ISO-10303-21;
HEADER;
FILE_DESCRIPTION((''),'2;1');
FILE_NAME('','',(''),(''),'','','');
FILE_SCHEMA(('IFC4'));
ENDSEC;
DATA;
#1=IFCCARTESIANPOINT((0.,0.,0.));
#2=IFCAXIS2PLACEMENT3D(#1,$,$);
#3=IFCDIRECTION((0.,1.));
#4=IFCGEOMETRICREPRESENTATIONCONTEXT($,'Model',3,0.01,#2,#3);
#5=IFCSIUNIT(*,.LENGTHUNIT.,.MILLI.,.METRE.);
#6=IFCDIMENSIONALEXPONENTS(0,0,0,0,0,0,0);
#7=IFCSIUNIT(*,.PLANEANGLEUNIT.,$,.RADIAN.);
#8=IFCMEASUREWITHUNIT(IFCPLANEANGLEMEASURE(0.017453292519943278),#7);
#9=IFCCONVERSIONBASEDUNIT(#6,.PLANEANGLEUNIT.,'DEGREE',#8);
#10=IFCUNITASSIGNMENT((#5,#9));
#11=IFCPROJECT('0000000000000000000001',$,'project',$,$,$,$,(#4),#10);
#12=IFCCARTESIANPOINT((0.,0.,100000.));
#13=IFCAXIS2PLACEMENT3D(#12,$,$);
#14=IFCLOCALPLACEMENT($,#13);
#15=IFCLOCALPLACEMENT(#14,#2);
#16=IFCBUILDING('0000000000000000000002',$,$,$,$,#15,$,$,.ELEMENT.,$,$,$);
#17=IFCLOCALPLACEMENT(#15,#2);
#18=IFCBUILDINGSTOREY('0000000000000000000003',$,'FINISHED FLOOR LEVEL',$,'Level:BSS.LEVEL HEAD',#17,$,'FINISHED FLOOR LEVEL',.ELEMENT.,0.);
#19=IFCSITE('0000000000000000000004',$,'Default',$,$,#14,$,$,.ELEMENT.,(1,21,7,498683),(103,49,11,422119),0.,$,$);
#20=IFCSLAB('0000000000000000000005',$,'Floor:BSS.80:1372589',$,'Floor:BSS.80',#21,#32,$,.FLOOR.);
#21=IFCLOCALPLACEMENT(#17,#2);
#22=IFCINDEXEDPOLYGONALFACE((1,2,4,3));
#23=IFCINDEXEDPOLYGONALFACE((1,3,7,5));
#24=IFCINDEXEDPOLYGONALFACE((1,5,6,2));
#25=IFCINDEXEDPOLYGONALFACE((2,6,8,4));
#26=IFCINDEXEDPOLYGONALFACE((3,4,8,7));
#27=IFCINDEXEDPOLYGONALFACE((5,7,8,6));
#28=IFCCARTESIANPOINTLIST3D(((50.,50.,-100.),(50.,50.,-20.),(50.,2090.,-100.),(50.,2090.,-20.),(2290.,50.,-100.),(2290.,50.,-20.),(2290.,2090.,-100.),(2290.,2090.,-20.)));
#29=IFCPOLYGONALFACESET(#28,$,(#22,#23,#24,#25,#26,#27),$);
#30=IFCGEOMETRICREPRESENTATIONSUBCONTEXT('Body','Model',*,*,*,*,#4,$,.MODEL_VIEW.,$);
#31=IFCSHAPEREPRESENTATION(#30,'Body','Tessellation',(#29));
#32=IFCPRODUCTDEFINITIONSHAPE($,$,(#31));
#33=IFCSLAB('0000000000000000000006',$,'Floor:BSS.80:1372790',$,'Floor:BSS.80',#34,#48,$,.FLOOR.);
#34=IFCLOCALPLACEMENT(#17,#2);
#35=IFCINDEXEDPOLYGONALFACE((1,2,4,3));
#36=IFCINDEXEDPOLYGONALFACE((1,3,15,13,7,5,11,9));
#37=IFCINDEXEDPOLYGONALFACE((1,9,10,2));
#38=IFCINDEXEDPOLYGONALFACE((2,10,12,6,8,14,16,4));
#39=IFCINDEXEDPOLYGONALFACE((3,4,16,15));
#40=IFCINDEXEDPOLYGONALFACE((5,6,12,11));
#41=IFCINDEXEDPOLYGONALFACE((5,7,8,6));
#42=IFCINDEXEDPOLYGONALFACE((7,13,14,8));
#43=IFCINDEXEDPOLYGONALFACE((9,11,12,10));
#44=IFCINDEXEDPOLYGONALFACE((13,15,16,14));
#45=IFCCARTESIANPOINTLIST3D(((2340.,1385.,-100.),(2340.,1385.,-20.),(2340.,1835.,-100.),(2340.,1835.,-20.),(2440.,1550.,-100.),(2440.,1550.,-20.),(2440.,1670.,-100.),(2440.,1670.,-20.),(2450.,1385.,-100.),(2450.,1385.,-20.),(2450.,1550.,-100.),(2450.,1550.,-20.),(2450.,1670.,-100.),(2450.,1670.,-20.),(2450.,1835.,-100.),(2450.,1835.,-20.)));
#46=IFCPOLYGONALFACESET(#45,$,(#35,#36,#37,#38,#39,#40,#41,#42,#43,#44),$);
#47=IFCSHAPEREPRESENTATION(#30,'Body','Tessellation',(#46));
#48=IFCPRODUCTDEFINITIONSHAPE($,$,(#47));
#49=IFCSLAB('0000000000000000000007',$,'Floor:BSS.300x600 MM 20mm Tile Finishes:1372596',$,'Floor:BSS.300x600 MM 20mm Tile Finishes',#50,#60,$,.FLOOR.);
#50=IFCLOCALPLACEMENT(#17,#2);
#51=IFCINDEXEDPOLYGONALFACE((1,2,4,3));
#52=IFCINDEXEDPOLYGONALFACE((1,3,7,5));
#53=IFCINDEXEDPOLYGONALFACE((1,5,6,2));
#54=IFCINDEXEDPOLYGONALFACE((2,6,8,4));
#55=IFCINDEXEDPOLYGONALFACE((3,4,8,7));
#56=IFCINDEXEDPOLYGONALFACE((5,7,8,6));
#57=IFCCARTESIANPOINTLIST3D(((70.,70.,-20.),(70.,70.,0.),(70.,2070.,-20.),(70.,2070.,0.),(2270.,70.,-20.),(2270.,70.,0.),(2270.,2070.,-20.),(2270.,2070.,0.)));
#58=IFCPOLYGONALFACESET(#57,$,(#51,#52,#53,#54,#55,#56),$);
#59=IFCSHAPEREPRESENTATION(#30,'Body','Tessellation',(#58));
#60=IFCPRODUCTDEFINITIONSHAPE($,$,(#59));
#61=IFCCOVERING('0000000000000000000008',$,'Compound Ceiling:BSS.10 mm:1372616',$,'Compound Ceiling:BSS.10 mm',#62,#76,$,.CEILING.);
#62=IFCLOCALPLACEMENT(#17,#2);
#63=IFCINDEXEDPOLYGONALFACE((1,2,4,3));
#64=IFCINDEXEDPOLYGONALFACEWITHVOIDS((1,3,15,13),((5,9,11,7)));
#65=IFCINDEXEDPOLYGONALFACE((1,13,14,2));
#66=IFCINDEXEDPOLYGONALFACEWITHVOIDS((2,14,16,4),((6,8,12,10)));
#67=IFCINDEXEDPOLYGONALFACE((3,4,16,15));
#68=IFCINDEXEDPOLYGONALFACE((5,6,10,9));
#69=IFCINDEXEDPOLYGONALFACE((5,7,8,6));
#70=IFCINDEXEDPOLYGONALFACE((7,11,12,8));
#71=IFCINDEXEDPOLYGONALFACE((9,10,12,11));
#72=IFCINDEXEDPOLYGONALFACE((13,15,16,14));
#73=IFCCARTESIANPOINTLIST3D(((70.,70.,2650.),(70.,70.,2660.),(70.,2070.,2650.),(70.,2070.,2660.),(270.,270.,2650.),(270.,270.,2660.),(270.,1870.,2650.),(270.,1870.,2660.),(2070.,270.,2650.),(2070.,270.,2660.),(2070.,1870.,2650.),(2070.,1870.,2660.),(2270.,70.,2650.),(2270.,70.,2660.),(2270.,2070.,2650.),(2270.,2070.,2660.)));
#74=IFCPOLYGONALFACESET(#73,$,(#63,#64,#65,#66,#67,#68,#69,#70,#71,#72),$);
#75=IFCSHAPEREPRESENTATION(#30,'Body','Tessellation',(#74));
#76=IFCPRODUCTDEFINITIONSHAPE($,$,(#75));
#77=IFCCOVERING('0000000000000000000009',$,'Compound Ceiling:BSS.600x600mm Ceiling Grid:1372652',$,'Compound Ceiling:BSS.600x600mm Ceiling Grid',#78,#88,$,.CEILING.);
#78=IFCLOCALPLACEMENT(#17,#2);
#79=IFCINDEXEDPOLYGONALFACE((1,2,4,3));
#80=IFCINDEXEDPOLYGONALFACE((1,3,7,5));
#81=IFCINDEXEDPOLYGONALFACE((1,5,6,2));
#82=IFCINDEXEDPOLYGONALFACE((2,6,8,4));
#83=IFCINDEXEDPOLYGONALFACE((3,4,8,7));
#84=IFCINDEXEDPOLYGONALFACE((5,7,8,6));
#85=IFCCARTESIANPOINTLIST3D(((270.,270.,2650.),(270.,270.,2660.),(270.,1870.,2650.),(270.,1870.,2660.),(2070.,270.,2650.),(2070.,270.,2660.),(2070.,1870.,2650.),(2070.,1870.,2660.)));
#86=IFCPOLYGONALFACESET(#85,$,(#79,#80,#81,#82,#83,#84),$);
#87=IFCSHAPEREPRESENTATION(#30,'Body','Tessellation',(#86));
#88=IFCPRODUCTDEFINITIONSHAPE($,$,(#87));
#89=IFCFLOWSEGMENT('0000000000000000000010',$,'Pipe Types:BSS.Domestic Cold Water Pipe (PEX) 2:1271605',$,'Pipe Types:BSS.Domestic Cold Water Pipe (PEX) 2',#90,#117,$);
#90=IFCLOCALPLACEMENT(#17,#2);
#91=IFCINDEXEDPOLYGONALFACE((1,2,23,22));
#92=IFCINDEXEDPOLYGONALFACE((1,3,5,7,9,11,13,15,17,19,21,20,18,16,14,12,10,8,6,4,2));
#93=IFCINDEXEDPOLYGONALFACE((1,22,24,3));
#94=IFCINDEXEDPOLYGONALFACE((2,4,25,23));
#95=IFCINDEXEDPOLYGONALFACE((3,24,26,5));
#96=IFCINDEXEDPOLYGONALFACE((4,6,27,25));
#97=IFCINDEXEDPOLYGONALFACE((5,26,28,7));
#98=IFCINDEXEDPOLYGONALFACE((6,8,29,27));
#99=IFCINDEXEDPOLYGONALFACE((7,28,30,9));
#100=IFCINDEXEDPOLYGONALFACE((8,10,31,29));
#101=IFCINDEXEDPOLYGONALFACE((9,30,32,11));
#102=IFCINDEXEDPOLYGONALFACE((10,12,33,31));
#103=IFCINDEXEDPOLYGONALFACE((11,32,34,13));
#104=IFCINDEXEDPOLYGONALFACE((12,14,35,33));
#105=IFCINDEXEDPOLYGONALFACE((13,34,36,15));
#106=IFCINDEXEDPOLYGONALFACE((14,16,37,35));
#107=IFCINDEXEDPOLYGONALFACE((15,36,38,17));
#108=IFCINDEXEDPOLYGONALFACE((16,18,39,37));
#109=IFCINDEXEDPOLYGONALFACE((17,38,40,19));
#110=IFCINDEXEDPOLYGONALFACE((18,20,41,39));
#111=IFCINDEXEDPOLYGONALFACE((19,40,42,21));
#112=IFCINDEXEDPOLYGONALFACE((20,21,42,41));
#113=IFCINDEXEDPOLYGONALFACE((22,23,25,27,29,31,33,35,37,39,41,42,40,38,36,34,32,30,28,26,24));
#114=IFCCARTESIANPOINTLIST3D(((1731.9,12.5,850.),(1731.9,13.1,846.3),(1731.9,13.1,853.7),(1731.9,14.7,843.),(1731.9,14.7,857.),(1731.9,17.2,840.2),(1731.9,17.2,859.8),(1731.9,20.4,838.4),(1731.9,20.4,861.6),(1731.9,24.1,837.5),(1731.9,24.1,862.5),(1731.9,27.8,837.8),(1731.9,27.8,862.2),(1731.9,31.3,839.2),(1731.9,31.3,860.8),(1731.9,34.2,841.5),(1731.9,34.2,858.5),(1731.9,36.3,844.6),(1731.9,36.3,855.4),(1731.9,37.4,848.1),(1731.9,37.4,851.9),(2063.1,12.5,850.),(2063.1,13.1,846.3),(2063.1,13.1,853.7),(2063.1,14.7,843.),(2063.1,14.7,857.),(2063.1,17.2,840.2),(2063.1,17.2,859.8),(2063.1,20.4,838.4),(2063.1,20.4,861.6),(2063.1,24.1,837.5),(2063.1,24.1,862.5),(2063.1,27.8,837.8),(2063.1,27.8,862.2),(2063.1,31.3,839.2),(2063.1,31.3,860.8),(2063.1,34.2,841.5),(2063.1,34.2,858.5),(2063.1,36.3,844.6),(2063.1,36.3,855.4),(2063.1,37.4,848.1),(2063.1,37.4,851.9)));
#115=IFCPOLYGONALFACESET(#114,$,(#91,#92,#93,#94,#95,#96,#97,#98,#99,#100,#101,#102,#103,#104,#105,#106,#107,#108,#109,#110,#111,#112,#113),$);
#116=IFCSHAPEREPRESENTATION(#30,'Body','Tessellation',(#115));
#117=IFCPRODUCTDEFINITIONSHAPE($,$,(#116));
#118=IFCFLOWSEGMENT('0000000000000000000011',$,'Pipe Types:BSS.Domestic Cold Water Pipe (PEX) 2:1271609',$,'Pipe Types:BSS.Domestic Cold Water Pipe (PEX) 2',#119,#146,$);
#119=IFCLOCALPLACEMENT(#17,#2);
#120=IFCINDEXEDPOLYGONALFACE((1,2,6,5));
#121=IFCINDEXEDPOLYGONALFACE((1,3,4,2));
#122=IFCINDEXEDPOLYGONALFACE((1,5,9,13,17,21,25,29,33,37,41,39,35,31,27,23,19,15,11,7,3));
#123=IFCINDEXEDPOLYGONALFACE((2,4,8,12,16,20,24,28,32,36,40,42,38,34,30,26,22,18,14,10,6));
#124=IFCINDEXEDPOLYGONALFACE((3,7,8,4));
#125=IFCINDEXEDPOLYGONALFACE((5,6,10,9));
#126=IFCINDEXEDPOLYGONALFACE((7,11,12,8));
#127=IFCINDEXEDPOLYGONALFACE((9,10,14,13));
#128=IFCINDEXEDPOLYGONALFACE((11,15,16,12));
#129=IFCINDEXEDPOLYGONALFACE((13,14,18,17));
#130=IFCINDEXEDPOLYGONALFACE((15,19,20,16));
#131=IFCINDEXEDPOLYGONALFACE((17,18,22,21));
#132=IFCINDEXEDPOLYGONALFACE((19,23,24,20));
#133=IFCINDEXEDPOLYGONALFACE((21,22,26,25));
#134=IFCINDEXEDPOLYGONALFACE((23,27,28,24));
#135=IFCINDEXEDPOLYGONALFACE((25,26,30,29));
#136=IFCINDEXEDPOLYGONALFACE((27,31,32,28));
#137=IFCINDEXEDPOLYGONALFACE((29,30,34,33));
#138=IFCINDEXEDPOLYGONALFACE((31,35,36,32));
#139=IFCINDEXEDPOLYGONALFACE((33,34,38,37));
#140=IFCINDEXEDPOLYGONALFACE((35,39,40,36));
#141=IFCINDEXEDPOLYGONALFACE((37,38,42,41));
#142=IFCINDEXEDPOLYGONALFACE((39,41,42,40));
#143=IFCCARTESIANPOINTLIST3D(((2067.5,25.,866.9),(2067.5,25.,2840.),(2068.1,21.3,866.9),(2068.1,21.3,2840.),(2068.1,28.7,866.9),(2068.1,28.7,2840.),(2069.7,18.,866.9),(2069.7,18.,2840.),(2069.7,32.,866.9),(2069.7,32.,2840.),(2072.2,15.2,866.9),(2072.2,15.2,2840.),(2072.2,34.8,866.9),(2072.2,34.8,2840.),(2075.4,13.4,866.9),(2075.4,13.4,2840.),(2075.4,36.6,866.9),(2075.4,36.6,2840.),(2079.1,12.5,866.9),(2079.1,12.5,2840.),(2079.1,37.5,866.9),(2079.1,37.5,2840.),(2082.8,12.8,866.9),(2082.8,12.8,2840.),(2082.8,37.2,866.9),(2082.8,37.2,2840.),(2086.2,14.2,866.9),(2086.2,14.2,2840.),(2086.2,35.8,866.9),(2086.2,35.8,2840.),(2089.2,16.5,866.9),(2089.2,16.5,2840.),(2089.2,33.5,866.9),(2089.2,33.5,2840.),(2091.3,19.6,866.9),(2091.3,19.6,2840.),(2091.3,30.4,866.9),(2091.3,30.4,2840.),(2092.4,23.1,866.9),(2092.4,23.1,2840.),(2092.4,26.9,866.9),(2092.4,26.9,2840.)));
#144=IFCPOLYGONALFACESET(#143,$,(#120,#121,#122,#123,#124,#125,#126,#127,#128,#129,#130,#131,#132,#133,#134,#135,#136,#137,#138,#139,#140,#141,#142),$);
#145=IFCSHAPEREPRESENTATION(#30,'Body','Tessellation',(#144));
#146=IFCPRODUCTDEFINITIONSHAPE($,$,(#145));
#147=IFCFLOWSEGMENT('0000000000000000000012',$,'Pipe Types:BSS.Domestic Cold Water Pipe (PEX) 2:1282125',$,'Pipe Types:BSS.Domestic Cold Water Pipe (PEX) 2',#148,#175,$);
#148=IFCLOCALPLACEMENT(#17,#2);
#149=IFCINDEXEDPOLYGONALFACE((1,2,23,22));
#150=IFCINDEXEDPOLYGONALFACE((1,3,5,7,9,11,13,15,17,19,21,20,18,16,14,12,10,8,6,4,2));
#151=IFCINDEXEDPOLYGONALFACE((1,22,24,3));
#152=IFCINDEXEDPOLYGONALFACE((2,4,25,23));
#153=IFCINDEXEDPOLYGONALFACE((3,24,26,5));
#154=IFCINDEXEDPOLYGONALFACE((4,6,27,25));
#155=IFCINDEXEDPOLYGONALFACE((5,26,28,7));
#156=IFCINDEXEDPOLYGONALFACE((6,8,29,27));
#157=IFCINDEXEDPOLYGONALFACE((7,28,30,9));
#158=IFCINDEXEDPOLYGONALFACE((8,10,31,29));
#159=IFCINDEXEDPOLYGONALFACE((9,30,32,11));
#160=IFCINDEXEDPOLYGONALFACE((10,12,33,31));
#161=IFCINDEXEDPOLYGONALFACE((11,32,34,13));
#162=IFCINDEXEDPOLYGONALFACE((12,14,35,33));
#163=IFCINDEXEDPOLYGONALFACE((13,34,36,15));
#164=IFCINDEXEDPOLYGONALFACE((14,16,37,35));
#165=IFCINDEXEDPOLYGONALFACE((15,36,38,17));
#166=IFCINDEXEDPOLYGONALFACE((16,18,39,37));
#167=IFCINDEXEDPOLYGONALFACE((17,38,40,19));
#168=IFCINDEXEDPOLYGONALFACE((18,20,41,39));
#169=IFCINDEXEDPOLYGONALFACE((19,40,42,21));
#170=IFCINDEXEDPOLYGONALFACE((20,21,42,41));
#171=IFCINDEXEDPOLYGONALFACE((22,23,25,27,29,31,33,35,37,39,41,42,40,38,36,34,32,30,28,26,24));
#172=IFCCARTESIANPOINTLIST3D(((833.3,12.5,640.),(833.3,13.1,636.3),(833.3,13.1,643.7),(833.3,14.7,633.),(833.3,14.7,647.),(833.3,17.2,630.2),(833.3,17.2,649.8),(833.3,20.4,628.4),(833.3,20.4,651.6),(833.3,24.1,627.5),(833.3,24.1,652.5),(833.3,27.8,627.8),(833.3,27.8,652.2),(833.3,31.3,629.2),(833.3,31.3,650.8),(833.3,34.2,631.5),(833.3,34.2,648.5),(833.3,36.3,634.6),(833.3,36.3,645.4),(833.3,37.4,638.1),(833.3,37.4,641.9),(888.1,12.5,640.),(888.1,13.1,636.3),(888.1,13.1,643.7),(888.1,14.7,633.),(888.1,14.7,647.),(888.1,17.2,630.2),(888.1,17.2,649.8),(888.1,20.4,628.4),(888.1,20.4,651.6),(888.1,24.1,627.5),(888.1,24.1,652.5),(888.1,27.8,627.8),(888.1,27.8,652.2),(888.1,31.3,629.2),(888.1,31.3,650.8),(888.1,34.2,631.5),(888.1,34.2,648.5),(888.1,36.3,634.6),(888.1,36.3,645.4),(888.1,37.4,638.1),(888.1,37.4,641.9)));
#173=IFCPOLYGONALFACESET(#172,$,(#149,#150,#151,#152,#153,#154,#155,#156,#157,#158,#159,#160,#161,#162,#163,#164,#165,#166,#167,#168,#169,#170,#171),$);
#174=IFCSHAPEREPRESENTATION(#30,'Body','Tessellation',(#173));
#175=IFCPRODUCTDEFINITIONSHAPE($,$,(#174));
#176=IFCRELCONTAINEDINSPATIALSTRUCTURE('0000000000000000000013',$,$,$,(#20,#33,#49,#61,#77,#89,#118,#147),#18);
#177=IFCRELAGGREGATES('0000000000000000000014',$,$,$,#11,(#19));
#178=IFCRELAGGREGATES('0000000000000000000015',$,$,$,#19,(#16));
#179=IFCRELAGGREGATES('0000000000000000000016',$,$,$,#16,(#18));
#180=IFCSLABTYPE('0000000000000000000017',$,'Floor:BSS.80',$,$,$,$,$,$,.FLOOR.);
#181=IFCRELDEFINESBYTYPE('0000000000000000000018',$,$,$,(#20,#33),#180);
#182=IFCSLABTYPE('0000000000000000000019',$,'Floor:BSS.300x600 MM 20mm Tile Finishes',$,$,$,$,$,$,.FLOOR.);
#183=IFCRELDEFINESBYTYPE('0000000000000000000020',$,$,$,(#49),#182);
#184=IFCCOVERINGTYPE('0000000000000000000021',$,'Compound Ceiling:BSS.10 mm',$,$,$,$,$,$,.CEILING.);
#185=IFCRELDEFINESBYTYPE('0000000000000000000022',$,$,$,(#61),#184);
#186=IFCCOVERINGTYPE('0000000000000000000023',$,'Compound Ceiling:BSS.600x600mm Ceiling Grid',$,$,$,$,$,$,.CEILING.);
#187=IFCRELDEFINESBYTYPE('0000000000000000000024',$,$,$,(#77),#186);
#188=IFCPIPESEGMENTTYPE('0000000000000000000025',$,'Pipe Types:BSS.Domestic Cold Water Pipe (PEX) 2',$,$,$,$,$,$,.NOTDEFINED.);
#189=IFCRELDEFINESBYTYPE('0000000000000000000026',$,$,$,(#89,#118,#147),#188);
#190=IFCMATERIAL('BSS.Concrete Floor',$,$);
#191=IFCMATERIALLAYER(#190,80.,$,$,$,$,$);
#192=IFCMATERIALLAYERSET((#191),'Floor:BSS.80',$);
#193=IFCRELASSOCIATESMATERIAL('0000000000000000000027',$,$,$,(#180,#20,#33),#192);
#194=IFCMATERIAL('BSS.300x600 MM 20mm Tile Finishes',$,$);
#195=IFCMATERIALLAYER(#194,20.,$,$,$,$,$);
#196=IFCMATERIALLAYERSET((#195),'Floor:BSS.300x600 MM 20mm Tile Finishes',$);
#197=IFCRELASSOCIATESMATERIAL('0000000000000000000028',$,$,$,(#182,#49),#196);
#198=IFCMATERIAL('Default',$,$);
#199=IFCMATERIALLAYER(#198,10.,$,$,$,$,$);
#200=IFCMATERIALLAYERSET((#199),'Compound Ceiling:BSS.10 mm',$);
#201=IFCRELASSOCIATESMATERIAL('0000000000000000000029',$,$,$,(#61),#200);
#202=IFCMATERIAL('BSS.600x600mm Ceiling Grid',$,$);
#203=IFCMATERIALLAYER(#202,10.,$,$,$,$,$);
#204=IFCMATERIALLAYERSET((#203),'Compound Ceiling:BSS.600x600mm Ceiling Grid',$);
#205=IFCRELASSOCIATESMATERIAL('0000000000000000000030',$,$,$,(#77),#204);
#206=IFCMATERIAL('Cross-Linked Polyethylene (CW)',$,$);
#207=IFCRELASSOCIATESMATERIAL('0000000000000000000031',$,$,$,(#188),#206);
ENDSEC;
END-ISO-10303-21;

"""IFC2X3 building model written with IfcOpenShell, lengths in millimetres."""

from ifc_helpers import new_model, entity, si_unit, converted_unit, direction, frame, frame_2d, origin, origin_2d_with_axis, place, context, subcontext, project, spatial, polyline, rectangle, circle, outline, extrude, material, layer, layer_set, layer_usage, type_object, element, save


model = new_model("IFC2X3")

# Units and contexts
model_context = context("Model", 3, precision=0.01, world=origin(), true_north=direction((0.0, 1.0)))
body_context = subcontext(model_context, "Body", "Model", "MODEL_VIEW")
ifc_project = project(units=[si_unit("LENGTHUNIT", "METRE", prefix="MILLI"), converted_unit("PLANEANGLEUNIT", "DEGREE", entity("IfcPlaneAngleMeasure", 0.017453292519943278), si_unit("PLANEANGLEUNIT", "RADIAN"), dimensions=[0, 0, 0, 0, 0, 0, 0])], contexts=[model_context])

# Site, building, storey
site_placement = place(None, frame((0.0, 0.0, 100000.0)))
site = spatial("IfcSite", under=ifc_project, at=site_placement, Name="Default", CompositionType="ELEMENT", RefLatitude=(1, 21, 7, 498683), RefLongitude=(103, 49, 11, 422119), RefElevation=0.0)
building_placement = place(site_placement, origin())
building = spatial("IfcBuilding", under=site, at=building_placement, CompositionType="ELEMENT")
storey_placement = place(building_placement, origin())
storey = spatial("IfcBuildingStorey", under=building, at=storey_placement, Name="FINISHED FLOOR LEVEL", ObjectType="Level:BSS.LEVEL HEAD", LongName="FINISHED FLOOR LEVEL", CompositionType="ELEMENT", Elevation=0.0)

# Slabs
ifc_material_1 = material(Name="BSS.Concrete Floor")
ifc_layer_1 = layer(ifc_material_1, 80.0)
ifc_layer_set_1 = layer_set([ifc_layer_1], Name="Floor:BSS.80")
ifc_layer_usage_1 = layer_usage(ifc_layer_set_1, "AXIS3", "POSITIVE", 0.0)
slab_type_1 = type_object("IfcSlabType", Name="Floor:BSS.80", PredefinedType="FLOOR", material=ifc_layer_set_1)
slab_1_placement = place(storey_placement, origin())
element("IfcSlab", 1, at=slab_1_placement, inside=storey, type_object=slab_type_1, material=ifc_layer_usage_1, Name="Floor:BSS.80:1372589", ObjectType="Floor:BSS.80", PredefinedType="FLOOR", context=body_context, shape_type="SweptSolid", body=[
    extrude(rectangle(XDim=2040.0, YDim=2240.0, at=origin_2d_with_axis()), frame((1170.0, 1070.0, -20.0), z_axis=(0.0, 0.0, -1.0), x_axis=(0.0, 1.0, 0.0)), (0.0, 0.0, 1.0), 80.0),
])
ifc_layer_usage_2 = layer_usage(ifc_layer_set_1, "AXIS3", "POSITIVE", 0.0)
slab_2_placement = place(storey_placement, origin())
element("IfcSlab", 2, at=slab_2_placement, inside=storey, type_object=slab_type_1, material=ifc_layer_usage_2, Name="Floor:BSS.80:1372790", ObjectType="Floor:BSS.80", PredefinedType="FLOOR", context=body_context, shape_type="SweptSolid", body=[
    extrude(outline(polyline([(-225.0, -80.0), (225.0, -80.0), (225.0, 30.0), (60.0, 30.0), (60.0, 20.0), (-60.0, 20.0), (-60.0, 30.0), (-225.0, 30.0), (-225.0, -80.0)])), frame((2420.0, 1610.0, -20.0), z_axis=(0.0, 0.0, -1.0), x_axis=(0.0, 1.0, 0.0)), (0.0, 0.0, 1.0), 80.0),
])
ifc_material_2 = material(Name="BSS.300x600 MM 20mm Tile Finishes")
ifc_layer_2 = layer(ifc_material_2, 20.0)
ifc_layer_set_2 = layer_set([ifc_layer_2], Name="Floor:BSS.300x600 MM 20mm Tile Finishes")
ifc_layer_usage_3 = layer_usage(ifc_layer_set_2, "AXIS3", "POSITIVE", 0.0)
slab_type_2 = type_object("IfcSlabType", Name="Floor:BSS.300x600 MM 20mm Tile Finishes", PredefinedType="FLOOR", material=ifc_layer_set_2)
slab_3_placement = place(storey_placement, origin())
element("IfcSlab", 3, at=slab_3_placement, inside=storey, type_object=slab_type_2, material=ifc_layer_usage_3, Name="Floor:BSS.300x600 MM 20mm Tile Finishes:1372596", ObjectType="Floor:BSS.300x600 MM 20mm Tile Finishes", PredefinedType="FLOOR", context=body_context, shape_type="SweptSolid", body=[
    extrude(rectangle(XDim=2000.0, YDim=2200.0, at=frame_2d((0.0, 0.0), x_axis=(1.0, 0.0))), frame((1170.0, 1070.0, 0.0), z_axis=(0.0, 0.0, -1.0), x_axis=(0.0, 1.0, 0.0)), (0.0, 0.0, 1.0), 20.0),
])

# Coverings
ifc_material_3 = material(Name="Default")
ifc_layer_3 = layer(ifc_material_3, 10.0)
ifc_layer_set_3 = layer_set([ifc_layer_3], Name="Compound Ceiling:BSS.10 mm")
ifc_layer_usage_4 = layer_usage(ifc_layer_set_3, "AXIS3", "NEGATIVE", 10.0)
covering_type_1 = type_object("IfcCoveringType", Name="Compound Ceiling:BSS.10 mm", PredefinedType="CEILING")
covering_1_placement = place(storey_placement, origin())
element("IfcCovering", 4, at=covering_1_placement, inside=storey, type_object=covering_type_1, material=ifc_layer_usage_4, Name="Compound Ceiling:BSS.10 mm:1372616", ObjectType="Compound Ceiling:BSS.10 mm", PredefinedType="CEILING", context=body_context, shape_type="SweptSolid", body=[
    extrude(outline(polyline([(-1100.0, -1000.0), (1100.0, -1000.0), (1100.0, 1000.0), (-1100.0, 1000.0), (-1100.0, -1000.0)]), holes=[polyline([(-900.0, -800.0), (-900.0, 800.0), (900.0, 800.0), (900.0, -800.0), (-900.0, -800.0)])]), frame((1170.0, 1070.0, 2650.0), z_axis=(0.0, 0.0, 1.0), x_axis=(-1.0, 0.0, 0.0)), (0.0, 0.0, 1.0), 10.0),
])
ifc_material_4 = material(Name="BSS.600x600mm Ceiling Grid")
ifc_layer_4 = layer(ifc_material_4, 10.0)
ifc_layer_set_4 = layer_set([ifc_layer_4], Name="Compound Ceiling:BSS.600x600mm Ceiling Grid")
ifc_layer_usage_5 = layer_usage(ifc_layer_set_4, "AXIS3", "NEGATIVE", 10.0)
covering_type_2 = type_object("IfcCoveringType", Name="Compound Ceiling:BSS.600x600mm Ceiling Grid", PredefinedType="CEILING")
covering_2_placement = place(storey_placement, origin())
element("IfcCovering", 5, at=covering_2_placement, inside=storey, type_object=covering_type_2, material=ifc_layer_usage_5, Name="Compound Ceiling:BSS.600x600mm Ceiling Grid:1372652", ObjectType="Compound Ceiling:BSS.600x600mm Ceiling Grid", PredefinedType="CEILING", context=body_context, shape_type="SweptSolid", body=[
    extrude(rectangle(XDim=1600.0, YDim=1800.0, at=frame_2d((0.0, 0.0), x_axis=(1.0, 0.0))), frame((1170.0, 1070.0, 2650.0), z_axis=(0.0, 0.0, 1.0), x_axis=(0.0, -1.0, 0.0)), (0.0, 0.0, 1.0), 10.0),
])

# Flow segments
ifc_material_5 = material(Name="Cross-Linked Polyethylene (CW)")
pipe_segment_type_1 = type_object("IfcPipeSegmentType", Name="Pipe Types:BSS.Domestic Cold Water Pipe (PEX) 2", PredefinedType="NOTDEFINED", material=ifc_material_5)
flow_segment_1_placement = place(storey_placement, origin())
element("IfcFlowSegment", 6, at=flow_segment_1_placement, inside=storey, type_object=pipe_segment_type_1, Name="Pipe Types:BSS.Domestic Cold Water Pipe (PEX) 2:1271605", ObjectType="Pipe Types:BSS.Domestic Cold Water Pipe (PEX) 2", context=body_context, shape_type="SweptSolid", body=[
    extrude(circle(Radius=12.5, at=frame_2d((0.0, 0.0), x_axis=(1.0, 0.0))), frame((1731.9, 25.0, 850.0), z_axis=(1.0, 0.0, 0.0), x_axis=(0.0, -1.0, 0.0)), (0.0, 0.0, 1.0), 331.1),
])
flow_segment_2_placement = place(storey_placement, origin())
element("IfcFlowSegment", 7, at=flow_segment_2_placement, inside=storey, type_object=pipe_segment_type_1, Name="Pipe Types:BSS.Domestic Cold Water Pipe (PEX) 2:1271609", ObjectType="Pipe Types:BSS.Domestic Cold Water Pipe (PEX) 2", context=body_context, shape_type="SweptSolid", body=[
    extrude(circle(Radius=12.5, at=frame_2d((0.0, 0.0), x_axis=(1.0, 0.0))), frame((2080.0, 25.0, 866.9), z_axis=(0.0, 0.0, 1.0), x_axis=(-1.0, 0.0, 0.0)), (0.0, 0.0, 1.0), 1973.1),
])
flow_segment_3_placement = place(storey_placement, origin())
element("IfcFlowSegment", 8, at=flow_segment_3_placement, inside=storey, type_object=pipe_segment_type_1, Name="Pipe Types:BSS.Domestic Cold Water Pipe (PEX) 2:1282125", ObjectType="Pipe Types:BSS.Domestic Cold Water Pipe (PEX) 2", context=body_context, shape_type="SweptSolid", body=[
    extrude(circle(Radius=12.5, at=frame_2d((0.0, 0.0), x_axis=(1.0, 0.0))), frame((833.3, 25.0, 640.0), z_axis=(1.0, 0.0, 0.0), x_axis=(0.0, -1.0, 0.0)), (0.0, 0.0, 1.0), 54.8),
])

save(model, "model.ifc")
